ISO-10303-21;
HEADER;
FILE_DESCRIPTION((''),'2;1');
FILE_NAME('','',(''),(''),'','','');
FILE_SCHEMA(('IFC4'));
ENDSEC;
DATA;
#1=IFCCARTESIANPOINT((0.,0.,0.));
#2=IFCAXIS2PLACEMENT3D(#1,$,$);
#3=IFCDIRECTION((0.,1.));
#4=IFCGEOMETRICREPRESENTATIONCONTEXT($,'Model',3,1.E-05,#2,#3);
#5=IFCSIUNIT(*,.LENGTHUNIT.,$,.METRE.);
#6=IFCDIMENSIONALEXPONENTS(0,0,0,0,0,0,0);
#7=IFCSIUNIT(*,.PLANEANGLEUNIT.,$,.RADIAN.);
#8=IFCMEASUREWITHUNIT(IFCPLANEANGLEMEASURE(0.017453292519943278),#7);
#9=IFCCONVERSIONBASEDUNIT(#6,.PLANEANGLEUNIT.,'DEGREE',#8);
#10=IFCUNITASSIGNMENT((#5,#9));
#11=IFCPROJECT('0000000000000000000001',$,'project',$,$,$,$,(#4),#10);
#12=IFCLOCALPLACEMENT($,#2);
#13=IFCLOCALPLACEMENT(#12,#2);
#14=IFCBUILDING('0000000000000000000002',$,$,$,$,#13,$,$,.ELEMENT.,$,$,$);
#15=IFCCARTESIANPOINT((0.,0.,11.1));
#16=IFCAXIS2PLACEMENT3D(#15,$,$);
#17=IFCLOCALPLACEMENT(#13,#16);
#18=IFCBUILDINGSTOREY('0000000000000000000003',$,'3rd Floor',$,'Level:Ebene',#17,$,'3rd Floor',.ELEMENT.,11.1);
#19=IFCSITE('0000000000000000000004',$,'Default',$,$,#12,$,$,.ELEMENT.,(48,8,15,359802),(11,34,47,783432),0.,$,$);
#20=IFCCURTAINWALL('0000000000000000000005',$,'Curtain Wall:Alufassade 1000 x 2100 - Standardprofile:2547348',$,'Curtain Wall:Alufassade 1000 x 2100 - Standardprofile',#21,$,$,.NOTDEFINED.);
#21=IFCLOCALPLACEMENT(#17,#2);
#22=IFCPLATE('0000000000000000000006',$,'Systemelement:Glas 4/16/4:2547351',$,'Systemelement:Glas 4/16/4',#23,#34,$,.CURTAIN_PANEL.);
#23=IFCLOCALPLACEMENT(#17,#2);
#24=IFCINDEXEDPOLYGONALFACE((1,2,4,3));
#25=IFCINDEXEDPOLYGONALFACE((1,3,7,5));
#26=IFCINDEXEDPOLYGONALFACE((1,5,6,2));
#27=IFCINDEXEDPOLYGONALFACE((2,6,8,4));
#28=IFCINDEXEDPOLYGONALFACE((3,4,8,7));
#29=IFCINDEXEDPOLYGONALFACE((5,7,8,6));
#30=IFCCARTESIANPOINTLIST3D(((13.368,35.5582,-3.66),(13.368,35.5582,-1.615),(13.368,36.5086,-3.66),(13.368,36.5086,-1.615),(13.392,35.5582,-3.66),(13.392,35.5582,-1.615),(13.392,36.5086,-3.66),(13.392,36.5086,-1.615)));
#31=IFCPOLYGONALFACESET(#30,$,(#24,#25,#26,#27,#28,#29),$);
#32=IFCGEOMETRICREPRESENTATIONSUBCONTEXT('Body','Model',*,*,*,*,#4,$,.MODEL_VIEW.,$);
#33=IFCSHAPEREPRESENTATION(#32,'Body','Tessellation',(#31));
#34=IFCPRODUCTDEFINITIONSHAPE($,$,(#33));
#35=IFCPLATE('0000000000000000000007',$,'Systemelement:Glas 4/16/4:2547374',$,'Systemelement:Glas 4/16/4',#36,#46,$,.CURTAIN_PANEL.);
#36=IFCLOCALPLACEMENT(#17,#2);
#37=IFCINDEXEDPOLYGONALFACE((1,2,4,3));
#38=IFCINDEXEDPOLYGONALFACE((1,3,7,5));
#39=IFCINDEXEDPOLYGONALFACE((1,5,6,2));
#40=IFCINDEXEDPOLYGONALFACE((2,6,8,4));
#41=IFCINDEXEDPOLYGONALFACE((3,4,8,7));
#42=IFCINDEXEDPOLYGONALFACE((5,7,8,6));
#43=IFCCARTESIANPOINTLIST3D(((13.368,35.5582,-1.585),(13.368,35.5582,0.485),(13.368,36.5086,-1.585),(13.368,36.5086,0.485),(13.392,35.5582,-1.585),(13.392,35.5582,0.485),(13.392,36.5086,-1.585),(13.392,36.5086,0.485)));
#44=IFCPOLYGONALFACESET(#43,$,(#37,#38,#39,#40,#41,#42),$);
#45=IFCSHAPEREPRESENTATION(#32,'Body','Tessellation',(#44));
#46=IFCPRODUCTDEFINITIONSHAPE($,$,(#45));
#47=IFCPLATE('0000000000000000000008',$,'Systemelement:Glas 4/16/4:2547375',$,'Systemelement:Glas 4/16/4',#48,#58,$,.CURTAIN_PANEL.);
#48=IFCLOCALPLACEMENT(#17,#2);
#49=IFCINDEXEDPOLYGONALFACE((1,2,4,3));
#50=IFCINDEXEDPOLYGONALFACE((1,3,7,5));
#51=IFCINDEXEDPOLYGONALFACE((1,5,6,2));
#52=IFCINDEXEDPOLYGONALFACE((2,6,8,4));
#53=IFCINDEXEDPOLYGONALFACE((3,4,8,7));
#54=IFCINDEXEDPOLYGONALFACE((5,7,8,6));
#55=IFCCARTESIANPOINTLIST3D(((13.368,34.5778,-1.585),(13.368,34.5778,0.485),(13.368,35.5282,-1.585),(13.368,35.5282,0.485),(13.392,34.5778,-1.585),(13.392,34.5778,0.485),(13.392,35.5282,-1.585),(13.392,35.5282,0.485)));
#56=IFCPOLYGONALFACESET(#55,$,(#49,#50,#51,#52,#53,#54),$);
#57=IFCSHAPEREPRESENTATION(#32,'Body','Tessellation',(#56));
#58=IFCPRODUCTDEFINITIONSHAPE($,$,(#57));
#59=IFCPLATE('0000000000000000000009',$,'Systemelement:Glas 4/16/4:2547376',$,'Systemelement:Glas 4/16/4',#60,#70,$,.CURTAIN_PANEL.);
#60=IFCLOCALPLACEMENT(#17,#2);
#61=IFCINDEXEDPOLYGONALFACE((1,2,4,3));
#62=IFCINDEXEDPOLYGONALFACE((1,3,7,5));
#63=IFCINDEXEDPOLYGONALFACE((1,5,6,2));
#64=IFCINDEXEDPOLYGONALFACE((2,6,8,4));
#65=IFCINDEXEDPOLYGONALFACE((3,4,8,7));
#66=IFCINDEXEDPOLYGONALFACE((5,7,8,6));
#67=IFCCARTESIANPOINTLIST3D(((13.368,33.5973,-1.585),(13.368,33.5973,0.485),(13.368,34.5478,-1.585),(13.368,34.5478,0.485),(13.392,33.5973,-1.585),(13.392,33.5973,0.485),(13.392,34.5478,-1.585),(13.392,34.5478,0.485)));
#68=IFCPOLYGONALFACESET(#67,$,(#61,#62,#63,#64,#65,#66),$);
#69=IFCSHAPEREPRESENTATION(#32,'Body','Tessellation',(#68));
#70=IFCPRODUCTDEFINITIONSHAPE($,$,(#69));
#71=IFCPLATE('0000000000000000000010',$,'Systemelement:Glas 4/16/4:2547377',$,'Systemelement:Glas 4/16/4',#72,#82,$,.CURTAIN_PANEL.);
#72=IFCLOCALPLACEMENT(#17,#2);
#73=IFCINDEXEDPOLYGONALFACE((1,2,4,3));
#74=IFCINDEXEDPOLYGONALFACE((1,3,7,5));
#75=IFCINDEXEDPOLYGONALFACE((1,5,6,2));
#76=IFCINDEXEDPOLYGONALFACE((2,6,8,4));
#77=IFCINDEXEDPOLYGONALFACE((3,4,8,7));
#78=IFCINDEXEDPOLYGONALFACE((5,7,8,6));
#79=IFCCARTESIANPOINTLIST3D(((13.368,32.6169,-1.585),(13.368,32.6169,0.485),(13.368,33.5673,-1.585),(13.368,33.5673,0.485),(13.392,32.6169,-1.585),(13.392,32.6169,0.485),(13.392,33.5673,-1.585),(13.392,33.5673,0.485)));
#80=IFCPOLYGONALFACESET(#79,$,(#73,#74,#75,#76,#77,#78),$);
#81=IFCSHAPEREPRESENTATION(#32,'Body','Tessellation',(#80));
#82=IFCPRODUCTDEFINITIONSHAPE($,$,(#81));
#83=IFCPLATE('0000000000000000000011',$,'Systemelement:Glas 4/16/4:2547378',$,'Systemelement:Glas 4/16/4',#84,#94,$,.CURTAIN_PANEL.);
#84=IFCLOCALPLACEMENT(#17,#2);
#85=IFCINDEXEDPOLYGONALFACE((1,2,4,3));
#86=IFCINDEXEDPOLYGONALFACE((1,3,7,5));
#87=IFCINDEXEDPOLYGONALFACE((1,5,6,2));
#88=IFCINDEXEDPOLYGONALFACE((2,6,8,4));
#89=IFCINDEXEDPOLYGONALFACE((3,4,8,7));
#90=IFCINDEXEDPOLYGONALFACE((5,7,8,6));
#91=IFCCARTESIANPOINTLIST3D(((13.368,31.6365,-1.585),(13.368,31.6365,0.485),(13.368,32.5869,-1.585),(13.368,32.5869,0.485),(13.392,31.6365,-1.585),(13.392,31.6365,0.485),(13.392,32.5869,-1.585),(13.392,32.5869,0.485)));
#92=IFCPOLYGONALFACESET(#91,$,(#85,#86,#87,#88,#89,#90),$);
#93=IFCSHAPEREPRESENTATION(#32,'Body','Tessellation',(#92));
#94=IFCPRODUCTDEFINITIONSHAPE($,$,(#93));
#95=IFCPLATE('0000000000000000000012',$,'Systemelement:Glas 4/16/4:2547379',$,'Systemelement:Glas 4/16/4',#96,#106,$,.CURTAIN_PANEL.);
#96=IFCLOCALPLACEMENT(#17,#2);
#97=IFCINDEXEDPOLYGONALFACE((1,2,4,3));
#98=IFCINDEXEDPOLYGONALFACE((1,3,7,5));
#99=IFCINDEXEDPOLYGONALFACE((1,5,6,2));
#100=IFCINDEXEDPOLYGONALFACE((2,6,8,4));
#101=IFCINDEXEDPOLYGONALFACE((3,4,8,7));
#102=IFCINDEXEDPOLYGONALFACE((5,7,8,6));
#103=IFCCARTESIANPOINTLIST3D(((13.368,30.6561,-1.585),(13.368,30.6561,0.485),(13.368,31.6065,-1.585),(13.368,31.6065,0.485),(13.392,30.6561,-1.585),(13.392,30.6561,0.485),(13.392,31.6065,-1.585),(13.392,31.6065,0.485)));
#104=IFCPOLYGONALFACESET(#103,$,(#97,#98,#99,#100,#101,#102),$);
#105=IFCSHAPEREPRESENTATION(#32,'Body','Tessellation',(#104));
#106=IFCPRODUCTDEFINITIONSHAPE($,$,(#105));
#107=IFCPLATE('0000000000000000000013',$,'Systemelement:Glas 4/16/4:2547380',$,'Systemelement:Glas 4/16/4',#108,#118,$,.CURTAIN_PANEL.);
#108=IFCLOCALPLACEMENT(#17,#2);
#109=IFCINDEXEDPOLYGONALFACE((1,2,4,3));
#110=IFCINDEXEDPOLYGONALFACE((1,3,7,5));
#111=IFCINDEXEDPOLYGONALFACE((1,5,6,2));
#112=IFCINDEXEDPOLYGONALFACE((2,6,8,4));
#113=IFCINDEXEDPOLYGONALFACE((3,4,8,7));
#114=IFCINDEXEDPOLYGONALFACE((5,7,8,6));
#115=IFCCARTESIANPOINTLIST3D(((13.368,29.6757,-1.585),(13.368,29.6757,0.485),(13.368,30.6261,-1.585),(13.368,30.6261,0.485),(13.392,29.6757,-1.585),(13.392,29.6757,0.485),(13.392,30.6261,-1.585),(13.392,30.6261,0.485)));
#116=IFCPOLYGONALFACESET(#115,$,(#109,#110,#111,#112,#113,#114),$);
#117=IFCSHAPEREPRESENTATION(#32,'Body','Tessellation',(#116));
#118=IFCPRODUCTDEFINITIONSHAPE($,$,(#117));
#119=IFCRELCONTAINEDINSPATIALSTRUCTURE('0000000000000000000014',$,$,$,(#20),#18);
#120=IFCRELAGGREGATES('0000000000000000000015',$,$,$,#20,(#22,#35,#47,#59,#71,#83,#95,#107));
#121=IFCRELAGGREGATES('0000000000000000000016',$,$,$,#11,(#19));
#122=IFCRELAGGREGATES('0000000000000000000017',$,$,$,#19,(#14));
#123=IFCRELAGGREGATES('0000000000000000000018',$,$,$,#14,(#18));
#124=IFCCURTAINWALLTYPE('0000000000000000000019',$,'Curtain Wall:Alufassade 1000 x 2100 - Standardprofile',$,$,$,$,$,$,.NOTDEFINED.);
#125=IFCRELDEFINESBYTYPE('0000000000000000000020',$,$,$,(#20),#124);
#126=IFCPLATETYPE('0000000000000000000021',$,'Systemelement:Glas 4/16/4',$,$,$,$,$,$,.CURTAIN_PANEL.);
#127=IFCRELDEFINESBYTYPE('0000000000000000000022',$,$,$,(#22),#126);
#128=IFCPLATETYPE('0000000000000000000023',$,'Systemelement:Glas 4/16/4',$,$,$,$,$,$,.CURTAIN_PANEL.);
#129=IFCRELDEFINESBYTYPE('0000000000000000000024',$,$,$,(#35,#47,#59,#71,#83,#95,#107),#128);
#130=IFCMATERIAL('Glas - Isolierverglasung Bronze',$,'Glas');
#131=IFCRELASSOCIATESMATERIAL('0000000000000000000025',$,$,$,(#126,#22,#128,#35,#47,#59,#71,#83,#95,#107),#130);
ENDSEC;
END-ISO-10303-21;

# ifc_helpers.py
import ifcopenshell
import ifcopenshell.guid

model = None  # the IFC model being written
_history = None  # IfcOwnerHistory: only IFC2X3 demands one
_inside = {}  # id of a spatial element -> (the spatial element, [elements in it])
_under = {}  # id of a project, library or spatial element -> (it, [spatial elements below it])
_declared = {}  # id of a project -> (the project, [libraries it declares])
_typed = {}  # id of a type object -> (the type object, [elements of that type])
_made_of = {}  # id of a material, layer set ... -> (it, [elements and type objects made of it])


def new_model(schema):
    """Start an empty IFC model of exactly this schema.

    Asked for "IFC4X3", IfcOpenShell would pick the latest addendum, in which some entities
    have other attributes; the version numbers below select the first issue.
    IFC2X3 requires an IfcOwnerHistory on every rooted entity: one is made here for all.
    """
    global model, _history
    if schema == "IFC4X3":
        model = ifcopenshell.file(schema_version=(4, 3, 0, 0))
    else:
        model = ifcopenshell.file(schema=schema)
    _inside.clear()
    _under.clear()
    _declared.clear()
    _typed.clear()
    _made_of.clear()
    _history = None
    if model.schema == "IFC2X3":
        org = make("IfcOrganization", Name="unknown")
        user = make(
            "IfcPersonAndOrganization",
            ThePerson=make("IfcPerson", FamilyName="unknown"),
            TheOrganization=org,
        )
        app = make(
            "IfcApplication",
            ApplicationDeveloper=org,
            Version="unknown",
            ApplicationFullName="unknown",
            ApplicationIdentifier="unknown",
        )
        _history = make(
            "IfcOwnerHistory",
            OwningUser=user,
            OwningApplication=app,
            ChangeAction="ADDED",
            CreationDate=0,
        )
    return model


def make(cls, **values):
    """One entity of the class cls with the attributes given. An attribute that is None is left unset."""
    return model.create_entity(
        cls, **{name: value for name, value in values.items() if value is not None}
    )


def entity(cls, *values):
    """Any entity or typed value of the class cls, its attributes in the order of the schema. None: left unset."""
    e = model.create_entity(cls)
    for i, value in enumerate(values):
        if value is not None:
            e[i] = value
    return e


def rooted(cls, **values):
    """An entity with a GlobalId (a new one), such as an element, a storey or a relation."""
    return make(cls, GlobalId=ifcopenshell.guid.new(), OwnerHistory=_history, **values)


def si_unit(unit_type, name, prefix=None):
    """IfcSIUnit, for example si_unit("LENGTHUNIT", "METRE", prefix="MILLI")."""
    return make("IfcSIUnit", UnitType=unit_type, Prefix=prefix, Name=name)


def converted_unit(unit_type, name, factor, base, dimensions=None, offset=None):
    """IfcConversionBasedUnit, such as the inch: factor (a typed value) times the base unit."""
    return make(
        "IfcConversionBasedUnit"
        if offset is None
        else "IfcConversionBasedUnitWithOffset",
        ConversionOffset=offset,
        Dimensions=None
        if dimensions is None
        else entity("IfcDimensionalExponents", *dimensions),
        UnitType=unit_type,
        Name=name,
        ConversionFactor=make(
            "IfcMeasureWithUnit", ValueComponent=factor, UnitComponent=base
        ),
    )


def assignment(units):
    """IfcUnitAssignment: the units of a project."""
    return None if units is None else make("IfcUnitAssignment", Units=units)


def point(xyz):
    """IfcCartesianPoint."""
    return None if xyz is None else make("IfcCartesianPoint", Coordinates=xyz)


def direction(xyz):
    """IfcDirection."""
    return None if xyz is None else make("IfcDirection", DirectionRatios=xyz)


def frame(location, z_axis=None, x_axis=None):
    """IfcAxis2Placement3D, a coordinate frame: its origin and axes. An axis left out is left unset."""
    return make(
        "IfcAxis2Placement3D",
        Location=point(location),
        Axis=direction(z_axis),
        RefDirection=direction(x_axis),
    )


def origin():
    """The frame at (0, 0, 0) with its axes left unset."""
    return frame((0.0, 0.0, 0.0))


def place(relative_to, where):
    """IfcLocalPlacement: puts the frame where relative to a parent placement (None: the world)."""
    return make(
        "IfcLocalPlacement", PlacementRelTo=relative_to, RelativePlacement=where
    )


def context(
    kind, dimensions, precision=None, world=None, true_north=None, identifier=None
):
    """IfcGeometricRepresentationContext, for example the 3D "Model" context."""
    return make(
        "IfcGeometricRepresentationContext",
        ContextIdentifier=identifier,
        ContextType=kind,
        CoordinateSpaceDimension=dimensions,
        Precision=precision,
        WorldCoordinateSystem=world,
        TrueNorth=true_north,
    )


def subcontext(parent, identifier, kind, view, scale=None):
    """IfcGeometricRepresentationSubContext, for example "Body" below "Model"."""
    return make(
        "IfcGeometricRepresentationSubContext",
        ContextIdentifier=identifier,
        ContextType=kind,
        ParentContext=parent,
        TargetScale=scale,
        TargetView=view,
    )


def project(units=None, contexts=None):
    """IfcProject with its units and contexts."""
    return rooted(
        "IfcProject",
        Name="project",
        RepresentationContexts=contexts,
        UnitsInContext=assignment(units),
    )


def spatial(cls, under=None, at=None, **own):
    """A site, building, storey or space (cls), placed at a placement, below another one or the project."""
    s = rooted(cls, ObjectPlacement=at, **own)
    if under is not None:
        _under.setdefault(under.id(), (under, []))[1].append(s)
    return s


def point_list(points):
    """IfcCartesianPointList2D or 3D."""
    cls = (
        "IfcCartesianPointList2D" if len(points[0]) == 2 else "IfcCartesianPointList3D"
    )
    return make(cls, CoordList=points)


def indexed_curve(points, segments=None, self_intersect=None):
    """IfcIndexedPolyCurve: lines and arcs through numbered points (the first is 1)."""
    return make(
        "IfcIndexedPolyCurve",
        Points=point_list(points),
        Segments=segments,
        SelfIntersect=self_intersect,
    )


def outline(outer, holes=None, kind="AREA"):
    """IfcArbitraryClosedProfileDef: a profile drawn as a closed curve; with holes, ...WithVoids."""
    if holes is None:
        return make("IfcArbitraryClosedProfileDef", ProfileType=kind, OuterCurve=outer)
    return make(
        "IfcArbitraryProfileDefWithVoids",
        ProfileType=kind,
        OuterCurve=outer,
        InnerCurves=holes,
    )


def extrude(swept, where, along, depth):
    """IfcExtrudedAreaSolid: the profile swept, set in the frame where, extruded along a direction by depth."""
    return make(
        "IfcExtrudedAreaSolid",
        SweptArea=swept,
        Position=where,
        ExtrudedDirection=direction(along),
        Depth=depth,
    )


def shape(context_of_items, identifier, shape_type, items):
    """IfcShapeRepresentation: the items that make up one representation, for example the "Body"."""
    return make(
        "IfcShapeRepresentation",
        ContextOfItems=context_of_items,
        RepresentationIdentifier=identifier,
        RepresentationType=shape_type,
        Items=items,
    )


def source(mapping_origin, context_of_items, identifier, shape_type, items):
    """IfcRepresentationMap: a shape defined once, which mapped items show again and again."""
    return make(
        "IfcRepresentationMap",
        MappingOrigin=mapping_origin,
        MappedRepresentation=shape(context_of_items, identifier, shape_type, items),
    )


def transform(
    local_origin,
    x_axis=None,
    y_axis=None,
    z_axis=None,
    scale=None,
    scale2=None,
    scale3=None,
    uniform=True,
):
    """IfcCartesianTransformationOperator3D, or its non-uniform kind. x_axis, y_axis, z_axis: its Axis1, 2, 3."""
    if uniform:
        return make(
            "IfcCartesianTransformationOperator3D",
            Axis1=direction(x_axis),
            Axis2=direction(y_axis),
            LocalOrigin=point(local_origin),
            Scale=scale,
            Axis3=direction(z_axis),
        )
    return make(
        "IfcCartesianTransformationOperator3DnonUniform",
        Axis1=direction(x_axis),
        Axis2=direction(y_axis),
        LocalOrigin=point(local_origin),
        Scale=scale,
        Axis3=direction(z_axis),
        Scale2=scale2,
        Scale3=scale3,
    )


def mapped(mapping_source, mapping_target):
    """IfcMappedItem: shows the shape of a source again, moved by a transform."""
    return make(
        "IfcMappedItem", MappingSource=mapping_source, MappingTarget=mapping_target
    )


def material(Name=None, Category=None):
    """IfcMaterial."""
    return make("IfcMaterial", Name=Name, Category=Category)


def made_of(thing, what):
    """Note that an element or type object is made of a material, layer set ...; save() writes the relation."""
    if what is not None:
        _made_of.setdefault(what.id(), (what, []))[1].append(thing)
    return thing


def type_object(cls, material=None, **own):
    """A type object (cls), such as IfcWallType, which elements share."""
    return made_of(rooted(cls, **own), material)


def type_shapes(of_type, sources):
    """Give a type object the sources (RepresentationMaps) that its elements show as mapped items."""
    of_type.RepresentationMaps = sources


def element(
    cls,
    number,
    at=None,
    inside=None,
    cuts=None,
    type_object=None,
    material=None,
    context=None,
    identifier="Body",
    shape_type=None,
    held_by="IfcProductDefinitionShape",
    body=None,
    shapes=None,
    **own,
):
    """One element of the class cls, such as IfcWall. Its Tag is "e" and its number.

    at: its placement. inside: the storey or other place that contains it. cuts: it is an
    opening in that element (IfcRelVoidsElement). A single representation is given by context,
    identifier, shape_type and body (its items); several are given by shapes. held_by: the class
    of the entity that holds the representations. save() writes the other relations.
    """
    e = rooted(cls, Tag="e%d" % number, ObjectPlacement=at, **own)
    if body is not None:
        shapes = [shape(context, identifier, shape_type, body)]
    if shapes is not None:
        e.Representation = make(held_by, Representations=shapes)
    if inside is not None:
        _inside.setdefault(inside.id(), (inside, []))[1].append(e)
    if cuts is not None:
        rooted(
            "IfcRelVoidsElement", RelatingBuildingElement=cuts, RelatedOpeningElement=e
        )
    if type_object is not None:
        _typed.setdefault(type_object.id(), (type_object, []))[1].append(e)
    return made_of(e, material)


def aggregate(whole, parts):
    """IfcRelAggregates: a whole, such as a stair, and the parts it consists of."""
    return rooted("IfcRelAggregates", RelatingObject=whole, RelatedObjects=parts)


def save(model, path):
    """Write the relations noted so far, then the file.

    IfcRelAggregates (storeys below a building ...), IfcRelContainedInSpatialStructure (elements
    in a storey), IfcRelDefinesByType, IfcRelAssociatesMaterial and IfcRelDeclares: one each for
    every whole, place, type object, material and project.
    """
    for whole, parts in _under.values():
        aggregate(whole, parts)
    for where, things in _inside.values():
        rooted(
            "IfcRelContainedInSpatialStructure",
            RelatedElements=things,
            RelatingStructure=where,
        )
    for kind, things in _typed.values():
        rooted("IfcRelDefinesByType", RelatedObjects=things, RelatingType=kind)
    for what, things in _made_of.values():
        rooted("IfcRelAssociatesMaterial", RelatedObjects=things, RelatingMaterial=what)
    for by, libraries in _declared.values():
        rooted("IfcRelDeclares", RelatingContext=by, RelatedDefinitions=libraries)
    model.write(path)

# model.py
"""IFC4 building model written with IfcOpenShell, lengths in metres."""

from ifc_helpers import new_model, entity, si_unit, converted_unit, direction, frame, origin, place, context, subcontext, project, spatial, indexed_curve, outline, extrude, source, transform, mapped, material, type_object, type_shapes, element, aggregate, save


model = new_model("IFC4")

# Units and contexts
model_context = context("Model", 3, precision=1e-05, world=origin(), true_north=direction((0.0, 1.0)))
body_context = subcontext(model_context, "Body", "Model", "MODEL_VIEW")
ifc_project = project(units=[si_unit("LENGTHUNIT", "METRE"), converted_unit("PLANEANGLEUNIT", "DEGREE", entity("IfcPlaneAngleMeasure", 0.017453292519943278), si_unit("PLANEANGLEUNIT", "RADIAN"), dimensions=[0, 0, 0, 0, 0, 0, 0])], contexts=[model_context])

# Site, building, storey
site_placement = place(None, origin())
site = spatial("IfcSite", under=ifc_project, at=site_placement, Name="Default", CompositionType="ELEMENT", RefLatitude=(48, 8, 15, 359802), RefLongitude=(11, 34, 47, 783432), RefElevation=0.0)
building_placement = place(site_placement, origin())
building = spatial("IfcBuilding", under=site, at=building_placement, CompositionType="ELEMENT")
storey_placement = place(building_placement, frame((0.0, 0.0, 11.1)))
storey = spatial("IfcBuildingStorey", under=building, at=storey_placement, Name="3rd Floor", ObjectType="Level:Ebene", LongName="3rd Floor", CompositionType="ELEMENT", Elevation=11.1)

# Curtain wall, plates
curtain_wall_type = type_object("IfcCurtainWallType", Name="Curtain Wall:Alufassade 1000 x 2100 - Standardprofile", PredefinedType="NOTDEFINED")
curtain_wall_placement = place(storey_placement, frame((0.0, 0.0, -11.1)))
curtain_wall = element("IfcCurtainWall", 1, at=curtain_wall_placement, inside=storey, type_object=curtain_wall_type, Name="Curtain Wall:Alufassade 1000 x 2100 - Standardprofile:2547348", ObjectType="Curtain Wall:Alufassade 1000 x 2100 - Standardprofile", PredefinedType="NOTDEFINED")
ifc_material_1 = material(Name="Glas - Isolierverglasung Bronze", Category="Glas")
plate_type_1 = type_object("IfcPlateType", Name="Systemelement:Glas 4/16/4", PredefinedType="CURTAIN_PANEL", material=ifc_material_1)
shared_shape_1 = source(origin(), body_context, "Body", "SweptSolid", [
    extrude(outline(indexed_curve([(-0.012, -0.4752), (0.012, -0.4752), (0.012, 0.4752), (-0.012, 0.4752), (-0.012, -0.4752)], self_intersect=False)), frame((0.0, 0.0, 0.0), z_axis=(0.0, 0.0, 1.0), x_axis=(0.0, 1.0, 0.0)), (0.0, 0.0, 1.0), 2.045),
])
type_shapes(plate_type_1, [shared_shape_1])
plate_1_placement = place(curtain_wall_placement, frame((13.38, 36.0334, 7.44), z_axis=(0.0, 0.0, 1.0), x_axis=(0.0, -1.0, 0.0)))
plate_1 = element("IfcPlate", 2, at=plate_1_placement, type_object=plate_type_1, material=ifc_material_1, Name="Systemelement:Glas 4/16/4:2547351", ObjectType="Systemelement:Glas 4/16/4", PredefinedType="CURTAIN_PANEL", context=body_context, shape_type="MappedRepresentation", body=[
    mapped(shared_shape_1, transform((0.0, 0.0, 0.0), scale=1.0)),
])
plate_type_2 = type_object("IfcPlateType", Name="Systemelement:Glas 4/16/4", PredefinedType="CURTAIN_PANEL", material=ifc_material_1)
shared_shape_2 = source(origin(), body_context, "Body", "SweptSolid", [
    extrude(outline(indexed_curve([(-0.012, -0.4752), (0.012, -0.4752), (0.012, 0.4752), (-0.012, 0.4752), (-0.012, -0.4752)], self_intersect=False)), frame((0.0, 0.0, 0.0), z_axis=(0.0, 0.0, 1.0), x_axis=(0.0, 1.0, 0.0)), (0.0, 0.0, 1.0), 2.07),
])
type_shapes(plate_type_2, [shared_shape_2])
plate_2_placement = place(curtain_wall_placement, frame((13.38, 36.0334, 9.515), z_axis=(0.0, 0.0, 1.0), x_axis=(0.0, -1.0, 0.0)))
plate_2 = element("IfcPlate", 3, at=plate_2_placement, type_object=plate_type_2, material=ifc_material_1, Name="Systemelement:Glas 4/16/4:2547374", ObjectType="Systemelement:Glas 4/16/4", PredefinedType="CURTAIN_PANEL", context=body_context, shape_type="MappedRepresentation", body=[
    mapped(shared_shape_2, transform((0.0, 0.0, 0.0), scale=1.0)),
])
plate_3_placement = place(curtain_wall_placement, frame((13.38, 35.053, 9.515), z_axis=(0.0, 0.0, 1.0), x_axis=(0.0, -1.0, 0.0)))
plate_3 = element("IfcPlate", 4, at=plate_3_placement, type_object=plate_type_2, material=ifc_material_1, Name="Systemelement:Glas 4/16/4:2547375", ObjectType="Systemelement:Glas 4/16/4", PredefinedType="CURTAIN_PANEL", context=body_context, shape_type="MappedRepresentation", body=[
    mapped(shared_shape_2, transform((0.0, 0.0, 0.0), scale=1.0)),
])
plate_4_placement = place(curtain_wall_placement, frame((13.38, 34.0725, 9.515), z_axis=(0.0, 0.0, 1.0), x_axis=(0.0, -1.0, 0.0)))
plate_4 = element("IfcPlate", 5, at=plate_4_placement, type_object=plate_type_2, material=ifc_material_1, Name="Systemelement:Glas 4/16/4:2547376", ObjectType="Systemelement:Glas 4/16/4", PredefinedType="CURTAIN_PANEL", context=body_context, shape_type="MappedRepresentation", body=[
    mapped(shared_shape_2, transform((0.0, 0.0, 0.0), scale=1.0)),
])
plate_5_placement = place(curtain_wall_placement, frame((13.38, 33.0921, 9.515), z_axis=(0.0, 0.0, 1.0), x_axis=(0.0, -1.0, 0.0)))
plate_5 = element("IfcPlate", 6, at=plate_5_placement, type_object=plate_type_2, material=ifc_material_1, Name="Systemelement:Glas 4/16/4:2547377", ObjectType="Systemelement:Glas 4/16/4", PredefinedType="CURTAIN_PANEL", context=body_context, shape_type="MappedRepresentation", body=[
    mapped(shared_shape_2, transform((0.0, 0.0, 0.0), scale=1.0)),
])
plate_6_placement = place(curtain_wall_placement, frame((13.38, 32.1117, 9.515), z_axis=(0.0, 0.0, 1.0), x_axis=(0.0, -1.0, 0.0)))
plate_6 = element("IfcPlate", 7, at=plate_6_placement, type_object=plate_type_2, material=ifc_material_1, Name="Systemelement:Glas 4/16/4:2547378", ObjectType="Systemelement:Glas 4/16/4", PredefinedType="CURTAIN_PANEL", context=body_context, shape_type="MappedRepresentation", body=[
    mapped(shared_shape_2, transform((0.0, 0.0, 0.0), scale=1.0)),
])
plate_7_placement = place(curtain_wall_placement, frame((13.38, 31.1313, 9.515), z_axis=(0.0, 0.0, 1.0), x_axis=(0.0, -1.0, 0.0)))
plate_7 = element("IfcPlate", 8, at=plate_7_placement, type_object=plate_type_2, material=ifc_material_1, Name="Systemelement:Glas 4/16/4:2547379", ObjectType="Systemelement:Glas 4/16/4", PredefinedType="CURTAIN_PANEL", context=body_context, shape_type="MappedRepresentation", body=[
    mapped(shared_shape_2, transform((0.0, 0.0, 0.0), scale=1.0)),
])
plate_8_placement = place(curtain_wall_placement, frame((13.38, 30.1509, 9.515), z_axis=(0.0, 0.0, 1.0), x_axis=(0.0, -1.0, 0.0)))
plate_8 = element("IfcPlate", 9, at=plate_8_placement, type_object=plate_type_2, material=ifc_material_1, Name="Systemelement:Glas 4/16/4:2547380", ObjectType="Systemelement:Glas 4/16/4", PredefinedType="CURTAIN_PANEL", context=body_context, shape_type="MappedRepresentation", body=[
    mapped(shared_shape_2, transform((0.0, 0.0, 0.0), scale=1.0)),
])
aggregate(curtain_wall, [plate_1, plate_2, plate_3, plate_4, plate_5, plate_6, plate_7, plate_8])

save(model, "model.ifc")
